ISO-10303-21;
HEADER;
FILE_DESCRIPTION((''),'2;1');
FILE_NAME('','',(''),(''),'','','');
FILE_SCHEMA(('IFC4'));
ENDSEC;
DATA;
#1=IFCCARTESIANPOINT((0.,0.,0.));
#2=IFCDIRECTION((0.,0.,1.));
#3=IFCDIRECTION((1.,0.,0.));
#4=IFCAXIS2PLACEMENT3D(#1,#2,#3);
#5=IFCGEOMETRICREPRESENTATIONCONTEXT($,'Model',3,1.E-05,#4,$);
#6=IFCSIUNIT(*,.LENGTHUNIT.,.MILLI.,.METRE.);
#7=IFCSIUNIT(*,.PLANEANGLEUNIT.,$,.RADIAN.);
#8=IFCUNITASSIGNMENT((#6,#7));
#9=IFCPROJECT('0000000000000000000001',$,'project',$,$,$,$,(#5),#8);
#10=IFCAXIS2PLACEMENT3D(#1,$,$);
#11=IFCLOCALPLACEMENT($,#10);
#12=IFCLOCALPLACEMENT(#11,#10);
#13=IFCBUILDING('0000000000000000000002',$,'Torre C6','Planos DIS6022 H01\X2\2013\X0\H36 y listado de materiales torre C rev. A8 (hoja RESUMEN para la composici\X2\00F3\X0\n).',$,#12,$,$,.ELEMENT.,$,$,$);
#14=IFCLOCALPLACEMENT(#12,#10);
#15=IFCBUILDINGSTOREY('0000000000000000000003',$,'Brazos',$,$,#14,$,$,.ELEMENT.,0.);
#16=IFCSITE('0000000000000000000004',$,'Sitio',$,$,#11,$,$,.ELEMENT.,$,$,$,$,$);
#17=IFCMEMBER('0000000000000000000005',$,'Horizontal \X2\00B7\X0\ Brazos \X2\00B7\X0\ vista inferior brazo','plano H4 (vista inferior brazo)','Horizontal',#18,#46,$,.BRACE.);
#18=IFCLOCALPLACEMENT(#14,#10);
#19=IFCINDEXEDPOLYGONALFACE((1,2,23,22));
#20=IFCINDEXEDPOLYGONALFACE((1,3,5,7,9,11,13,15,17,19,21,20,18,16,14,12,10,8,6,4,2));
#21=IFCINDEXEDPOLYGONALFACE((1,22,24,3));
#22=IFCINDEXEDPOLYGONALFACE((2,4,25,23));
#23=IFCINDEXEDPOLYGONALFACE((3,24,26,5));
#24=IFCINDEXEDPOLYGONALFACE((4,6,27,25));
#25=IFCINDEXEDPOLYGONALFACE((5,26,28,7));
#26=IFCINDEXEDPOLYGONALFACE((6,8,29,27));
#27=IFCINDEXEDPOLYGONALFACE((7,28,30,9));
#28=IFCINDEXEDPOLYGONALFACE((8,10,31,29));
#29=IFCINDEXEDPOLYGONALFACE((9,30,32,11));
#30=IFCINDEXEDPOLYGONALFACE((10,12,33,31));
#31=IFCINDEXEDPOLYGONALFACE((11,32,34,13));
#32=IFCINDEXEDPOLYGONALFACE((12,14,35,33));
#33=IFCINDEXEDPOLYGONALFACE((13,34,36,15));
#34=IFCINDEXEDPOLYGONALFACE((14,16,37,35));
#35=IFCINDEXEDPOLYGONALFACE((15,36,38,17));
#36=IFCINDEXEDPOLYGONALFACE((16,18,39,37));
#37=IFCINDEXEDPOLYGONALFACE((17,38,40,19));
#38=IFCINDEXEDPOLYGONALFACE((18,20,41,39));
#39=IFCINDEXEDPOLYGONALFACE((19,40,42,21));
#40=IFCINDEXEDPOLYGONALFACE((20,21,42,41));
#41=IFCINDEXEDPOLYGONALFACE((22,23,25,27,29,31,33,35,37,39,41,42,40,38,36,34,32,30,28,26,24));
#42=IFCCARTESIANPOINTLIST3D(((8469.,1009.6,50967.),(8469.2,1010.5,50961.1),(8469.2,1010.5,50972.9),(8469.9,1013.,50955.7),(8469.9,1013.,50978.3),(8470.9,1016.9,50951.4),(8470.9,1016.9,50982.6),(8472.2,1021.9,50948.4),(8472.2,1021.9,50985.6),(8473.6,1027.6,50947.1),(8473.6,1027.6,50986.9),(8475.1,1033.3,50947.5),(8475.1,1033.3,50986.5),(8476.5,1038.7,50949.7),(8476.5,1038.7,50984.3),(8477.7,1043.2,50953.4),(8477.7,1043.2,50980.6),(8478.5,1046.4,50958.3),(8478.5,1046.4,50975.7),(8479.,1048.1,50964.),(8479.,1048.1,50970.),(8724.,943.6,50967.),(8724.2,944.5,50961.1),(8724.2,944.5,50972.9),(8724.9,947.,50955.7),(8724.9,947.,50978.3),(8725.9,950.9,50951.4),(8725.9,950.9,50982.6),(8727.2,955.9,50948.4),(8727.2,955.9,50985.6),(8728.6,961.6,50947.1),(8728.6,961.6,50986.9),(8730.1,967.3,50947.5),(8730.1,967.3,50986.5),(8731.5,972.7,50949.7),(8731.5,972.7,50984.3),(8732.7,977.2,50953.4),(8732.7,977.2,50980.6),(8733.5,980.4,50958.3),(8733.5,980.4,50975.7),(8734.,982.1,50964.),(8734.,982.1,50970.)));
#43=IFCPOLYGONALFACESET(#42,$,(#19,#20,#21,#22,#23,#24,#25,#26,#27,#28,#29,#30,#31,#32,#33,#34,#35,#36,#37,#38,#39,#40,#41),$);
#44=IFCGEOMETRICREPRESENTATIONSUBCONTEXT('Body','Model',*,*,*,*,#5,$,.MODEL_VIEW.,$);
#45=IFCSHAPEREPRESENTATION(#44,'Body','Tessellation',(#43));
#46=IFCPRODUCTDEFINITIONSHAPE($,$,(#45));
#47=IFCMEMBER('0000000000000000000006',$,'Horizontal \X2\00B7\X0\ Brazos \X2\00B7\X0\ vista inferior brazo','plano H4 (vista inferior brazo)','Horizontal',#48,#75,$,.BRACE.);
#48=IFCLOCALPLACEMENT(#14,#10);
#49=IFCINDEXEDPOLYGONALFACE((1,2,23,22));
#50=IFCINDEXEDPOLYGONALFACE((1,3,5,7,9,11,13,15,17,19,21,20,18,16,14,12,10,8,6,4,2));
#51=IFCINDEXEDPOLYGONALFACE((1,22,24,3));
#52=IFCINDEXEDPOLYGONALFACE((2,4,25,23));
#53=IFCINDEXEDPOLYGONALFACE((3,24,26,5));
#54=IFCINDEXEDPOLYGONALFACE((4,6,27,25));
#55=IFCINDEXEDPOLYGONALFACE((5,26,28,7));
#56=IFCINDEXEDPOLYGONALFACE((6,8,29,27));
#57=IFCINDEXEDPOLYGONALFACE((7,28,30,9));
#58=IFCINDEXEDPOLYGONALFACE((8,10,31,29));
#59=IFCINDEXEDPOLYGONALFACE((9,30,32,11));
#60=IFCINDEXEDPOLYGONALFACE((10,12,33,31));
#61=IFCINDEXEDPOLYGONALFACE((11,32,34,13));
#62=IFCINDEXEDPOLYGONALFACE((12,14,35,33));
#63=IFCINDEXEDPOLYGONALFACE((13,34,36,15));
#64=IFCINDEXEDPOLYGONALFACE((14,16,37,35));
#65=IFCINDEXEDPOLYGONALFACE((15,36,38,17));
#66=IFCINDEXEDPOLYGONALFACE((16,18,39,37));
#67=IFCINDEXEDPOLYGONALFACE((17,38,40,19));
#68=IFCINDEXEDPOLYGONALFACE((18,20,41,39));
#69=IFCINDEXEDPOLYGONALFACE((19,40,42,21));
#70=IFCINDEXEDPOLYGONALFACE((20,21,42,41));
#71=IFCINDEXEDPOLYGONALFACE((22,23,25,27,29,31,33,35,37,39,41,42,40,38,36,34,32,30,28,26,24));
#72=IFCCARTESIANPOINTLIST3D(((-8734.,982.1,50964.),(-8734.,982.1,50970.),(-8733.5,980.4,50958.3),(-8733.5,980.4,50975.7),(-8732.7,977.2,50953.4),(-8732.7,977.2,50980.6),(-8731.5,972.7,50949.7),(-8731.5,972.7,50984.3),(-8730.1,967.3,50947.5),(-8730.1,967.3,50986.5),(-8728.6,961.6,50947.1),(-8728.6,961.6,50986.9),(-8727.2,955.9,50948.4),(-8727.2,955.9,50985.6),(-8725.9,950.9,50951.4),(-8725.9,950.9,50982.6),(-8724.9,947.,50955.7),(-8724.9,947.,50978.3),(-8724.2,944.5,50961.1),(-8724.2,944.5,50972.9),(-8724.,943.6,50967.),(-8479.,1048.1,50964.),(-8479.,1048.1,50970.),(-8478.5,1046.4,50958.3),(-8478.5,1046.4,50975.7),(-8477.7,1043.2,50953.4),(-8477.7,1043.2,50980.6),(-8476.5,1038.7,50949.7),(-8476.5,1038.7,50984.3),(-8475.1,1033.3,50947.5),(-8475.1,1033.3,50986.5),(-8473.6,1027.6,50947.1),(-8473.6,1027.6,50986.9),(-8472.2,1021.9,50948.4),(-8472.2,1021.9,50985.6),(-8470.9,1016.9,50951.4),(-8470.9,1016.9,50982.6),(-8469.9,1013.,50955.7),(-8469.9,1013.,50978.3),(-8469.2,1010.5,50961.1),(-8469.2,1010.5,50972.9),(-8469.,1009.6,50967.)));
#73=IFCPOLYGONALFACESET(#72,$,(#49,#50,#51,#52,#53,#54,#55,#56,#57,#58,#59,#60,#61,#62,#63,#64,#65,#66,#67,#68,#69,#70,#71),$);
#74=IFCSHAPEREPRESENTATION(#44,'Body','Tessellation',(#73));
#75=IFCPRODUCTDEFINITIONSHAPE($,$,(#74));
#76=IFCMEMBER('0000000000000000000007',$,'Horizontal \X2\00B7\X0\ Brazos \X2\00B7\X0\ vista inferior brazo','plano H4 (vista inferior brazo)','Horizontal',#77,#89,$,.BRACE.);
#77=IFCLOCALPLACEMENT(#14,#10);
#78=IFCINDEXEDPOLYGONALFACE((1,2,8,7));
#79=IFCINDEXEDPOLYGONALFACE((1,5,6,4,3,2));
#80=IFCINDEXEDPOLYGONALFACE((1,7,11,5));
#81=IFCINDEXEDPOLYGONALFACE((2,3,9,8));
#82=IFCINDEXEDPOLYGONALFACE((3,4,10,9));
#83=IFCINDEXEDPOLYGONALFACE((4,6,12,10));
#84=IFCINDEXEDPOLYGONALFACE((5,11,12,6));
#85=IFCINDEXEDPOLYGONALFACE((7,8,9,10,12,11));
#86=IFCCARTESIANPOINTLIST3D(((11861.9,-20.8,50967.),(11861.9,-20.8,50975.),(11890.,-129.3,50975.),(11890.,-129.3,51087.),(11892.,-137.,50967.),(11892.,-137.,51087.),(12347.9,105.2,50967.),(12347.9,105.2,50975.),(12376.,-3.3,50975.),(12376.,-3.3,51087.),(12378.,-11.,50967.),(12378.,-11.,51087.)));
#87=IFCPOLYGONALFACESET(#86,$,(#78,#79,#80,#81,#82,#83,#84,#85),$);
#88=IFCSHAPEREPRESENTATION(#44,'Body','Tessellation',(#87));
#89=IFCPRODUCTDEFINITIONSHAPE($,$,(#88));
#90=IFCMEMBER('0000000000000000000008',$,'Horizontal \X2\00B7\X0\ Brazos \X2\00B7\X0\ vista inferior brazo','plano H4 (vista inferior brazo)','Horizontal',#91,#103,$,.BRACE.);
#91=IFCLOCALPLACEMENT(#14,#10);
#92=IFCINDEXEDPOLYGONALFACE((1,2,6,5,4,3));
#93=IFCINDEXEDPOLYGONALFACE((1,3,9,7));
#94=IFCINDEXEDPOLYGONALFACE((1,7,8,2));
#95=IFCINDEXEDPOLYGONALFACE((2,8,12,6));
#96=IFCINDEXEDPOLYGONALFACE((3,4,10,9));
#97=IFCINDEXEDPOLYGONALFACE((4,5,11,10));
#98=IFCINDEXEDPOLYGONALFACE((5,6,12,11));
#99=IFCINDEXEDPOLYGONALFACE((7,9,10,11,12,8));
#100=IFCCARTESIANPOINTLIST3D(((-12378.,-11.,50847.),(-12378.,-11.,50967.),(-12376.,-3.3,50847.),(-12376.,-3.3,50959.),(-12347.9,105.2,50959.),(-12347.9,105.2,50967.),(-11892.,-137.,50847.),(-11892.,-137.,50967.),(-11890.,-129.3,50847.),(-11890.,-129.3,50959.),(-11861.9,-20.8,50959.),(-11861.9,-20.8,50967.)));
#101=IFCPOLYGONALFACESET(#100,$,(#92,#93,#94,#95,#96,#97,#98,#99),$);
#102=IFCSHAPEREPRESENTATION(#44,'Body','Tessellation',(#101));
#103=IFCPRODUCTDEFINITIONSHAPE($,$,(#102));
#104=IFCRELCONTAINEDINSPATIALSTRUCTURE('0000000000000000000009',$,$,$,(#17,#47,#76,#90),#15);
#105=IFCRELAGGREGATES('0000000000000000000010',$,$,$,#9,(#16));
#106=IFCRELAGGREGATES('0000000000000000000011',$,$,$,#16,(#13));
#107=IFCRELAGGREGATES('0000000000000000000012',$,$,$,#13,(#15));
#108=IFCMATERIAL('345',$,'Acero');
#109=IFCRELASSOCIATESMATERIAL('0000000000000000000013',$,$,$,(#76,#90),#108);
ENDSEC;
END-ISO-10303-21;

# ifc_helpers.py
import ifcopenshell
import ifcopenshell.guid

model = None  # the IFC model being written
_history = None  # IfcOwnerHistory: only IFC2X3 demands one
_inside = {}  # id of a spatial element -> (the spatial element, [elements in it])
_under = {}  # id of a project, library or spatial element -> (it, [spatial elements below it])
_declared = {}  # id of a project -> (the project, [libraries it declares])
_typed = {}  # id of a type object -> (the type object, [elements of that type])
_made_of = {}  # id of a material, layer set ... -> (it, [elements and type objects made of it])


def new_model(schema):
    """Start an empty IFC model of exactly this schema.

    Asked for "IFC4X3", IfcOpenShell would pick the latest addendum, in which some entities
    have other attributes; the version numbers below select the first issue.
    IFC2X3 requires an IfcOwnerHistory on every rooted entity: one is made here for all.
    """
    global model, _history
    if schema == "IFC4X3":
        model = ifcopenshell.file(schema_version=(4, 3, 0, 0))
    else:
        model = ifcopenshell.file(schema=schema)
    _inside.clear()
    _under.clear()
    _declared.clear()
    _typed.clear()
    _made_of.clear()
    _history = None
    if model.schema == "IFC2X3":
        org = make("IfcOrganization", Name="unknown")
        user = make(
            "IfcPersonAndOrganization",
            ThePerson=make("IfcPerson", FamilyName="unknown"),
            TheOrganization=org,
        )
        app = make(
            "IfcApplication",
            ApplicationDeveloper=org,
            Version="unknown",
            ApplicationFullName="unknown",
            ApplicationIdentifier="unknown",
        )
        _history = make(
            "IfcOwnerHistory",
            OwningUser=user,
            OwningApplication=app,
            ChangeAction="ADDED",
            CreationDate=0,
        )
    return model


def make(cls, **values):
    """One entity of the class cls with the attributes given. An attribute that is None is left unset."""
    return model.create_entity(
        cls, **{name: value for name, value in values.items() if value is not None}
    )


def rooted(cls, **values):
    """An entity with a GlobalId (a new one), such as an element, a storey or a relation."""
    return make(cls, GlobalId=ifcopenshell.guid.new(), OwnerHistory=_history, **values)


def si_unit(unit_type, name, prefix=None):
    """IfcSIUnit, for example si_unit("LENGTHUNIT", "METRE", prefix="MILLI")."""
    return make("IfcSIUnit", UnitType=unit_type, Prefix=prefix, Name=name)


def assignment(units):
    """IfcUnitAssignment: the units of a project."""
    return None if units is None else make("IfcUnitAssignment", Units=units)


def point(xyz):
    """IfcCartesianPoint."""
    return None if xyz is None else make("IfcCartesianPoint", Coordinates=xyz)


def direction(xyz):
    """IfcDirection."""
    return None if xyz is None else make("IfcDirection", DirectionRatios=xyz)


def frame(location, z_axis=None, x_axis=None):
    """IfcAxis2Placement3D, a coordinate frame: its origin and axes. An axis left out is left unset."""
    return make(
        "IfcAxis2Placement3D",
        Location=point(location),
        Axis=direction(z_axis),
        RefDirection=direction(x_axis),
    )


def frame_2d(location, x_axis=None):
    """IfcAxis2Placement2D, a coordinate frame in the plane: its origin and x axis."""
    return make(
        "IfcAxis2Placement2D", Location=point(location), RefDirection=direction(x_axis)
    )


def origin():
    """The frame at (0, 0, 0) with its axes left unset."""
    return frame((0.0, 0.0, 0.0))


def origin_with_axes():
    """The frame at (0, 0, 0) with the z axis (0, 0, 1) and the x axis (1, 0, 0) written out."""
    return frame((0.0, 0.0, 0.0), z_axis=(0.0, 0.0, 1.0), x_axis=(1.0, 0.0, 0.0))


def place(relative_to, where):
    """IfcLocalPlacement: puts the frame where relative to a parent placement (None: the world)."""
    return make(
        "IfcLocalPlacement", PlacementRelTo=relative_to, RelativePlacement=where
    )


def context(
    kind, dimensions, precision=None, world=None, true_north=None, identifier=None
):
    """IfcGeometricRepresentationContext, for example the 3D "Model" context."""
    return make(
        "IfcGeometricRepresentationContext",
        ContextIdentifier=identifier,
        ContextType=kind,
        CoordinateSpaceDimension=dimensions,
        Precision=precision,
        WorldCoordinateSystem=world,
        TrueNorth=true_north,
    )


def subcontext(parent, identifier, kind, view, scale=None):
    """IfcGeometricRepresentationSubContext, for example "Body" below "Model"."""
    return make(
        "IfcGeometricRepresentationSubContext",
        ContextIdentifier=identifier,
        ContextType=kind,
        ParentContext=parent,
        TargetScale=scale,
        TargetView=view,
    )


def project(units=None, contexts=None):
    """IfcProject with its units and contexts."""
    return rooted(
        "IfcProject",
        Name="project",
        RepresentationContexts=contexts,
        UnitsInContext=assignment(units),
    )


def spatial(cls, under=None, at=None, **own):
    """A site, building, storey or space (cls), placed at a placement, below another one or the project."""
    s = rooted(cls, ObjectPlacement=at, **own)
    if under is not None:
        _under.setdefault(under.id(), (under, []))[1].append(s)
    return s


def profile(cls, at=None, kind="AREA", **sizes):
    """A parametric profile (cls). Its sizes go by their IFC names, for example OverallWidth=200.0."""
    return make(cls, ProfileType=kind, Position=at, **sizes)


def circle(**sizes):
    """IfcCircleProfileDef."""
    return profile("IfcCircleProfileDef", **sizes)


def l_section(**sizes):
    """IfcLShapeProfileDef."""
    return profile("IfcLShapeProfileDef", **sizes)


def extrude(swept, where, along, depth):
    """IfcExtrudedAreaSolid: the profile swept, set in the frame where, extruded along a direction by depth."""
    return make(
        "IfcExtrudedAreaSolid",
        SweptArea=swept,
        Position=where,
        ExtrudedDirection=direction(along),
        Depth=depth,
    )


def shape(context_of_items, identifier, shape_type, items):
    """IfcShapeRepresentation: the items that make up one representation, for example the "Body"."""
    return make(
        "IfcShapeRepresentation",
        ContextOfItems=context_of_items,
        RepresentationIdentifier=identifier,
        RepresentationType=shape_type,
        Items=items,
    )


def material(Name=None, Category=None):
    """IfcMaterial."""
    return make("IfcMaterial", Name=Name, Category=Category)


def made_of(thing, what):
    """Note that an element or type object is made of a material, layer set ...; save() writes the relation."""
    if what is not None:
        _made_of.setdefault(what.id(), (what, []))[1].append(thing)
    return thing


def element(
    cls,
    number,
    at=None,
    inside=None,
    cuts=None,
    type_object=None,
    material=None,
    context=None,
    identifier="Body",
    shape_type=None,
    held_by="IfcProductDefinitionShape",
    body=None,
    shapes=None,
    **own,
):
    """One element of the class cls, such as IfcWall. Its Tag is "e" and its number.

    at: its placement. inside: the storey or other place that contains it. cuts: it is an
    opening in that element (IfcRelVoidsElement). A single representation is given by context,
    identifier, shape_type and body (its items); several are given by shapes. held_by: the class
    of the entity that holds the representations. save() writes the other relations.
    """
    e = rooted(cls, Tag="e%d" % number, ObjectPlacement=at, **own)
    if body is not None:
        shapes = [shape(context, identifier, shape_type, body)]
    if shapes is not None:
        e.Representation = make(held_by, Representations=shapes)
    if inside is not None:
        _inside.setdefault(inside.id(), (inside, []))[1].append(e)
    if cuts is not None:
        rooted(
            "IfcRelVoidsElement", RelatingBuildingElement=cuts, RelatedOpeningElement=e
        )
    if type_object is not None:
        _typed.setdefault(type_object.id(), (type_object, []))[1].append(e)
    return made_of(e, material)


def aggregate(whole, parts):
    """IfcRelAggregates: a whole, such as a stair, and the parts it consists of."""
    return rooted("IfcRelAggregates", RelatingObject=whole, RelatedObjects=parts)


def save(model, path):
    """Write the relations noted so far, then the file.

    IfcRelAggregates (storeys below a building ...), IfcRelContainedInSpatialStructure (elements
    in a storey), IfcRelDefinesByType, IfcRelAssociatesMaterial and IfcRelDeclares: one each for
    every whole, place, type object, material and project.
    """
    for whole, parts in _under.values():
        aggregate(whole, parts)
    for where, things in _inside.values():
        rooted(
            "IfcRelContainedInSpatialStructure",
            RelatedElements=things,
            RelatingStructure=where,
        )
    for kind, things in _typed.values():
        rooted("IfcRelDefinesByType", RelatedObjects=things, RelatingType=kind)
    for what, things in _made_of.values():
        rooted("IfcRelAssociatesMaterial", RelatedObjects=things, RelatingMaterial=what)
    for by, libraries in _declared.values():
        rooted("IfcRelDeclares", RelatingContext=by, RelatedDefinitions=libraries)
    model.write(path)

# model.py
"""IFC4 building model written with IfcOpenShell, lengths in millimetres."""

from ifc_helpers import new_model, si_unit, frame, frame_2d, origin, origin_with_axes, place, context, subcontext, project, spatial, circle, l_section, extrude, material, element, save


model = new_model("IFC4")

# Units and contexts
model_context = context("Model", 3, precision=1e-05, world=origin_with_axes())
body_context = subcontext(model_context, "Body", "Model", "MODEL_VIEW")
ifc_project = project(units=[si_unit("LENGTHUNIT", "METRE", prefix="MILLI"), si_unit("PLANEANGLEUNIT", "RADIAN")], contexts=[model_context])

# Site, building, storey
site_placement = place(None, origin())
site = spatial("IfcSite", under=ifc_project, at=site_placement, Name="Sitio", CompositionType="ELEMENT")
building_placement = place(site_placement, origin())
building = spatial("IfcBuilding", under=site, at=building_placement, Name="Torre C6", Description="Planos DIS6022 H01–H36 y listado de materiales torre C rev. A8 (hoja RESUMEN para la composición).", CompositionType="ELEMENT")
storey_placement = place(building_placement, origin())
storey = spatial("IfcBuildingStorey", under=building, at=storey_placement, Name="Brazos", CompositionType="ELEMENT", Elevation=0.0)

# Members
ifc_material_1 = material(Name="345", Category="Acero")
for number, where, z_axis, x_axis, name in (
    (1, (8474.0, 1029.0, 50967.0), (0.968099, -0.250567, 0.0), (-0.250567, -0.968099, 0.0), "Horizontal · Brazos · vista inferior brazo"),
    (2, (-8474.0, 1029.0, 50967.0), (-0.968099, -0.250567, 0.0), (0.250567, -0.968099, 0.0), "Horizontal · Brazos · vista inferior brazo"),
):
    element("IfcMember", number, at=place(storey_placement, frame(where, z_axis=z_axis, x_axis=x_axis)), inside=storey, Name=name, Description="plano H4 (vista inferior brazo)", ObjectType="Horizontal", PredefinedType="BRACE", context=body_context, shape_type="SweptSolid", body=[
        extrude(circle(Radius=20.0), None, (0.0, 0.0, 1.0), 263.4),
    ])
for number, where, z_axis, x_axis, name in (
    (3, (11892.0, -137.0, 50967.0), (0.967997, 0.250962, 0.0), (-0.250962, 0.967997, 0.0), "Horizontal · Brazos · vista inferior brazo"),
    (4, (-11892.0, -137.0, 50967.0), (-0.967997, 0.250962, 0.0), (0.250962, 0.967997, 0.0), "Horizontal · Brazos · vista inferior brazo"),
):
    element("IfcMember", number, at=place(storey_placement, frame(where, z_axis=z_axis, x_axis=x_axis)), inside=storey, material=ifc_material_1, Name=name, Description="plano H4 (vista inferior brazo)", ObjectType="Horizontal", PredefinedType="BRACE", context=body_context, shape_type="SweptSolid", body=[
        extrude(l_section(Depth=120.0, Width=120.0, Thickness=8.0, at=frame_2d((60.0, 60.0))), None, (0.0, 0.0, 1.0), 502.1),
    ])

save(model, "model.ifc")
